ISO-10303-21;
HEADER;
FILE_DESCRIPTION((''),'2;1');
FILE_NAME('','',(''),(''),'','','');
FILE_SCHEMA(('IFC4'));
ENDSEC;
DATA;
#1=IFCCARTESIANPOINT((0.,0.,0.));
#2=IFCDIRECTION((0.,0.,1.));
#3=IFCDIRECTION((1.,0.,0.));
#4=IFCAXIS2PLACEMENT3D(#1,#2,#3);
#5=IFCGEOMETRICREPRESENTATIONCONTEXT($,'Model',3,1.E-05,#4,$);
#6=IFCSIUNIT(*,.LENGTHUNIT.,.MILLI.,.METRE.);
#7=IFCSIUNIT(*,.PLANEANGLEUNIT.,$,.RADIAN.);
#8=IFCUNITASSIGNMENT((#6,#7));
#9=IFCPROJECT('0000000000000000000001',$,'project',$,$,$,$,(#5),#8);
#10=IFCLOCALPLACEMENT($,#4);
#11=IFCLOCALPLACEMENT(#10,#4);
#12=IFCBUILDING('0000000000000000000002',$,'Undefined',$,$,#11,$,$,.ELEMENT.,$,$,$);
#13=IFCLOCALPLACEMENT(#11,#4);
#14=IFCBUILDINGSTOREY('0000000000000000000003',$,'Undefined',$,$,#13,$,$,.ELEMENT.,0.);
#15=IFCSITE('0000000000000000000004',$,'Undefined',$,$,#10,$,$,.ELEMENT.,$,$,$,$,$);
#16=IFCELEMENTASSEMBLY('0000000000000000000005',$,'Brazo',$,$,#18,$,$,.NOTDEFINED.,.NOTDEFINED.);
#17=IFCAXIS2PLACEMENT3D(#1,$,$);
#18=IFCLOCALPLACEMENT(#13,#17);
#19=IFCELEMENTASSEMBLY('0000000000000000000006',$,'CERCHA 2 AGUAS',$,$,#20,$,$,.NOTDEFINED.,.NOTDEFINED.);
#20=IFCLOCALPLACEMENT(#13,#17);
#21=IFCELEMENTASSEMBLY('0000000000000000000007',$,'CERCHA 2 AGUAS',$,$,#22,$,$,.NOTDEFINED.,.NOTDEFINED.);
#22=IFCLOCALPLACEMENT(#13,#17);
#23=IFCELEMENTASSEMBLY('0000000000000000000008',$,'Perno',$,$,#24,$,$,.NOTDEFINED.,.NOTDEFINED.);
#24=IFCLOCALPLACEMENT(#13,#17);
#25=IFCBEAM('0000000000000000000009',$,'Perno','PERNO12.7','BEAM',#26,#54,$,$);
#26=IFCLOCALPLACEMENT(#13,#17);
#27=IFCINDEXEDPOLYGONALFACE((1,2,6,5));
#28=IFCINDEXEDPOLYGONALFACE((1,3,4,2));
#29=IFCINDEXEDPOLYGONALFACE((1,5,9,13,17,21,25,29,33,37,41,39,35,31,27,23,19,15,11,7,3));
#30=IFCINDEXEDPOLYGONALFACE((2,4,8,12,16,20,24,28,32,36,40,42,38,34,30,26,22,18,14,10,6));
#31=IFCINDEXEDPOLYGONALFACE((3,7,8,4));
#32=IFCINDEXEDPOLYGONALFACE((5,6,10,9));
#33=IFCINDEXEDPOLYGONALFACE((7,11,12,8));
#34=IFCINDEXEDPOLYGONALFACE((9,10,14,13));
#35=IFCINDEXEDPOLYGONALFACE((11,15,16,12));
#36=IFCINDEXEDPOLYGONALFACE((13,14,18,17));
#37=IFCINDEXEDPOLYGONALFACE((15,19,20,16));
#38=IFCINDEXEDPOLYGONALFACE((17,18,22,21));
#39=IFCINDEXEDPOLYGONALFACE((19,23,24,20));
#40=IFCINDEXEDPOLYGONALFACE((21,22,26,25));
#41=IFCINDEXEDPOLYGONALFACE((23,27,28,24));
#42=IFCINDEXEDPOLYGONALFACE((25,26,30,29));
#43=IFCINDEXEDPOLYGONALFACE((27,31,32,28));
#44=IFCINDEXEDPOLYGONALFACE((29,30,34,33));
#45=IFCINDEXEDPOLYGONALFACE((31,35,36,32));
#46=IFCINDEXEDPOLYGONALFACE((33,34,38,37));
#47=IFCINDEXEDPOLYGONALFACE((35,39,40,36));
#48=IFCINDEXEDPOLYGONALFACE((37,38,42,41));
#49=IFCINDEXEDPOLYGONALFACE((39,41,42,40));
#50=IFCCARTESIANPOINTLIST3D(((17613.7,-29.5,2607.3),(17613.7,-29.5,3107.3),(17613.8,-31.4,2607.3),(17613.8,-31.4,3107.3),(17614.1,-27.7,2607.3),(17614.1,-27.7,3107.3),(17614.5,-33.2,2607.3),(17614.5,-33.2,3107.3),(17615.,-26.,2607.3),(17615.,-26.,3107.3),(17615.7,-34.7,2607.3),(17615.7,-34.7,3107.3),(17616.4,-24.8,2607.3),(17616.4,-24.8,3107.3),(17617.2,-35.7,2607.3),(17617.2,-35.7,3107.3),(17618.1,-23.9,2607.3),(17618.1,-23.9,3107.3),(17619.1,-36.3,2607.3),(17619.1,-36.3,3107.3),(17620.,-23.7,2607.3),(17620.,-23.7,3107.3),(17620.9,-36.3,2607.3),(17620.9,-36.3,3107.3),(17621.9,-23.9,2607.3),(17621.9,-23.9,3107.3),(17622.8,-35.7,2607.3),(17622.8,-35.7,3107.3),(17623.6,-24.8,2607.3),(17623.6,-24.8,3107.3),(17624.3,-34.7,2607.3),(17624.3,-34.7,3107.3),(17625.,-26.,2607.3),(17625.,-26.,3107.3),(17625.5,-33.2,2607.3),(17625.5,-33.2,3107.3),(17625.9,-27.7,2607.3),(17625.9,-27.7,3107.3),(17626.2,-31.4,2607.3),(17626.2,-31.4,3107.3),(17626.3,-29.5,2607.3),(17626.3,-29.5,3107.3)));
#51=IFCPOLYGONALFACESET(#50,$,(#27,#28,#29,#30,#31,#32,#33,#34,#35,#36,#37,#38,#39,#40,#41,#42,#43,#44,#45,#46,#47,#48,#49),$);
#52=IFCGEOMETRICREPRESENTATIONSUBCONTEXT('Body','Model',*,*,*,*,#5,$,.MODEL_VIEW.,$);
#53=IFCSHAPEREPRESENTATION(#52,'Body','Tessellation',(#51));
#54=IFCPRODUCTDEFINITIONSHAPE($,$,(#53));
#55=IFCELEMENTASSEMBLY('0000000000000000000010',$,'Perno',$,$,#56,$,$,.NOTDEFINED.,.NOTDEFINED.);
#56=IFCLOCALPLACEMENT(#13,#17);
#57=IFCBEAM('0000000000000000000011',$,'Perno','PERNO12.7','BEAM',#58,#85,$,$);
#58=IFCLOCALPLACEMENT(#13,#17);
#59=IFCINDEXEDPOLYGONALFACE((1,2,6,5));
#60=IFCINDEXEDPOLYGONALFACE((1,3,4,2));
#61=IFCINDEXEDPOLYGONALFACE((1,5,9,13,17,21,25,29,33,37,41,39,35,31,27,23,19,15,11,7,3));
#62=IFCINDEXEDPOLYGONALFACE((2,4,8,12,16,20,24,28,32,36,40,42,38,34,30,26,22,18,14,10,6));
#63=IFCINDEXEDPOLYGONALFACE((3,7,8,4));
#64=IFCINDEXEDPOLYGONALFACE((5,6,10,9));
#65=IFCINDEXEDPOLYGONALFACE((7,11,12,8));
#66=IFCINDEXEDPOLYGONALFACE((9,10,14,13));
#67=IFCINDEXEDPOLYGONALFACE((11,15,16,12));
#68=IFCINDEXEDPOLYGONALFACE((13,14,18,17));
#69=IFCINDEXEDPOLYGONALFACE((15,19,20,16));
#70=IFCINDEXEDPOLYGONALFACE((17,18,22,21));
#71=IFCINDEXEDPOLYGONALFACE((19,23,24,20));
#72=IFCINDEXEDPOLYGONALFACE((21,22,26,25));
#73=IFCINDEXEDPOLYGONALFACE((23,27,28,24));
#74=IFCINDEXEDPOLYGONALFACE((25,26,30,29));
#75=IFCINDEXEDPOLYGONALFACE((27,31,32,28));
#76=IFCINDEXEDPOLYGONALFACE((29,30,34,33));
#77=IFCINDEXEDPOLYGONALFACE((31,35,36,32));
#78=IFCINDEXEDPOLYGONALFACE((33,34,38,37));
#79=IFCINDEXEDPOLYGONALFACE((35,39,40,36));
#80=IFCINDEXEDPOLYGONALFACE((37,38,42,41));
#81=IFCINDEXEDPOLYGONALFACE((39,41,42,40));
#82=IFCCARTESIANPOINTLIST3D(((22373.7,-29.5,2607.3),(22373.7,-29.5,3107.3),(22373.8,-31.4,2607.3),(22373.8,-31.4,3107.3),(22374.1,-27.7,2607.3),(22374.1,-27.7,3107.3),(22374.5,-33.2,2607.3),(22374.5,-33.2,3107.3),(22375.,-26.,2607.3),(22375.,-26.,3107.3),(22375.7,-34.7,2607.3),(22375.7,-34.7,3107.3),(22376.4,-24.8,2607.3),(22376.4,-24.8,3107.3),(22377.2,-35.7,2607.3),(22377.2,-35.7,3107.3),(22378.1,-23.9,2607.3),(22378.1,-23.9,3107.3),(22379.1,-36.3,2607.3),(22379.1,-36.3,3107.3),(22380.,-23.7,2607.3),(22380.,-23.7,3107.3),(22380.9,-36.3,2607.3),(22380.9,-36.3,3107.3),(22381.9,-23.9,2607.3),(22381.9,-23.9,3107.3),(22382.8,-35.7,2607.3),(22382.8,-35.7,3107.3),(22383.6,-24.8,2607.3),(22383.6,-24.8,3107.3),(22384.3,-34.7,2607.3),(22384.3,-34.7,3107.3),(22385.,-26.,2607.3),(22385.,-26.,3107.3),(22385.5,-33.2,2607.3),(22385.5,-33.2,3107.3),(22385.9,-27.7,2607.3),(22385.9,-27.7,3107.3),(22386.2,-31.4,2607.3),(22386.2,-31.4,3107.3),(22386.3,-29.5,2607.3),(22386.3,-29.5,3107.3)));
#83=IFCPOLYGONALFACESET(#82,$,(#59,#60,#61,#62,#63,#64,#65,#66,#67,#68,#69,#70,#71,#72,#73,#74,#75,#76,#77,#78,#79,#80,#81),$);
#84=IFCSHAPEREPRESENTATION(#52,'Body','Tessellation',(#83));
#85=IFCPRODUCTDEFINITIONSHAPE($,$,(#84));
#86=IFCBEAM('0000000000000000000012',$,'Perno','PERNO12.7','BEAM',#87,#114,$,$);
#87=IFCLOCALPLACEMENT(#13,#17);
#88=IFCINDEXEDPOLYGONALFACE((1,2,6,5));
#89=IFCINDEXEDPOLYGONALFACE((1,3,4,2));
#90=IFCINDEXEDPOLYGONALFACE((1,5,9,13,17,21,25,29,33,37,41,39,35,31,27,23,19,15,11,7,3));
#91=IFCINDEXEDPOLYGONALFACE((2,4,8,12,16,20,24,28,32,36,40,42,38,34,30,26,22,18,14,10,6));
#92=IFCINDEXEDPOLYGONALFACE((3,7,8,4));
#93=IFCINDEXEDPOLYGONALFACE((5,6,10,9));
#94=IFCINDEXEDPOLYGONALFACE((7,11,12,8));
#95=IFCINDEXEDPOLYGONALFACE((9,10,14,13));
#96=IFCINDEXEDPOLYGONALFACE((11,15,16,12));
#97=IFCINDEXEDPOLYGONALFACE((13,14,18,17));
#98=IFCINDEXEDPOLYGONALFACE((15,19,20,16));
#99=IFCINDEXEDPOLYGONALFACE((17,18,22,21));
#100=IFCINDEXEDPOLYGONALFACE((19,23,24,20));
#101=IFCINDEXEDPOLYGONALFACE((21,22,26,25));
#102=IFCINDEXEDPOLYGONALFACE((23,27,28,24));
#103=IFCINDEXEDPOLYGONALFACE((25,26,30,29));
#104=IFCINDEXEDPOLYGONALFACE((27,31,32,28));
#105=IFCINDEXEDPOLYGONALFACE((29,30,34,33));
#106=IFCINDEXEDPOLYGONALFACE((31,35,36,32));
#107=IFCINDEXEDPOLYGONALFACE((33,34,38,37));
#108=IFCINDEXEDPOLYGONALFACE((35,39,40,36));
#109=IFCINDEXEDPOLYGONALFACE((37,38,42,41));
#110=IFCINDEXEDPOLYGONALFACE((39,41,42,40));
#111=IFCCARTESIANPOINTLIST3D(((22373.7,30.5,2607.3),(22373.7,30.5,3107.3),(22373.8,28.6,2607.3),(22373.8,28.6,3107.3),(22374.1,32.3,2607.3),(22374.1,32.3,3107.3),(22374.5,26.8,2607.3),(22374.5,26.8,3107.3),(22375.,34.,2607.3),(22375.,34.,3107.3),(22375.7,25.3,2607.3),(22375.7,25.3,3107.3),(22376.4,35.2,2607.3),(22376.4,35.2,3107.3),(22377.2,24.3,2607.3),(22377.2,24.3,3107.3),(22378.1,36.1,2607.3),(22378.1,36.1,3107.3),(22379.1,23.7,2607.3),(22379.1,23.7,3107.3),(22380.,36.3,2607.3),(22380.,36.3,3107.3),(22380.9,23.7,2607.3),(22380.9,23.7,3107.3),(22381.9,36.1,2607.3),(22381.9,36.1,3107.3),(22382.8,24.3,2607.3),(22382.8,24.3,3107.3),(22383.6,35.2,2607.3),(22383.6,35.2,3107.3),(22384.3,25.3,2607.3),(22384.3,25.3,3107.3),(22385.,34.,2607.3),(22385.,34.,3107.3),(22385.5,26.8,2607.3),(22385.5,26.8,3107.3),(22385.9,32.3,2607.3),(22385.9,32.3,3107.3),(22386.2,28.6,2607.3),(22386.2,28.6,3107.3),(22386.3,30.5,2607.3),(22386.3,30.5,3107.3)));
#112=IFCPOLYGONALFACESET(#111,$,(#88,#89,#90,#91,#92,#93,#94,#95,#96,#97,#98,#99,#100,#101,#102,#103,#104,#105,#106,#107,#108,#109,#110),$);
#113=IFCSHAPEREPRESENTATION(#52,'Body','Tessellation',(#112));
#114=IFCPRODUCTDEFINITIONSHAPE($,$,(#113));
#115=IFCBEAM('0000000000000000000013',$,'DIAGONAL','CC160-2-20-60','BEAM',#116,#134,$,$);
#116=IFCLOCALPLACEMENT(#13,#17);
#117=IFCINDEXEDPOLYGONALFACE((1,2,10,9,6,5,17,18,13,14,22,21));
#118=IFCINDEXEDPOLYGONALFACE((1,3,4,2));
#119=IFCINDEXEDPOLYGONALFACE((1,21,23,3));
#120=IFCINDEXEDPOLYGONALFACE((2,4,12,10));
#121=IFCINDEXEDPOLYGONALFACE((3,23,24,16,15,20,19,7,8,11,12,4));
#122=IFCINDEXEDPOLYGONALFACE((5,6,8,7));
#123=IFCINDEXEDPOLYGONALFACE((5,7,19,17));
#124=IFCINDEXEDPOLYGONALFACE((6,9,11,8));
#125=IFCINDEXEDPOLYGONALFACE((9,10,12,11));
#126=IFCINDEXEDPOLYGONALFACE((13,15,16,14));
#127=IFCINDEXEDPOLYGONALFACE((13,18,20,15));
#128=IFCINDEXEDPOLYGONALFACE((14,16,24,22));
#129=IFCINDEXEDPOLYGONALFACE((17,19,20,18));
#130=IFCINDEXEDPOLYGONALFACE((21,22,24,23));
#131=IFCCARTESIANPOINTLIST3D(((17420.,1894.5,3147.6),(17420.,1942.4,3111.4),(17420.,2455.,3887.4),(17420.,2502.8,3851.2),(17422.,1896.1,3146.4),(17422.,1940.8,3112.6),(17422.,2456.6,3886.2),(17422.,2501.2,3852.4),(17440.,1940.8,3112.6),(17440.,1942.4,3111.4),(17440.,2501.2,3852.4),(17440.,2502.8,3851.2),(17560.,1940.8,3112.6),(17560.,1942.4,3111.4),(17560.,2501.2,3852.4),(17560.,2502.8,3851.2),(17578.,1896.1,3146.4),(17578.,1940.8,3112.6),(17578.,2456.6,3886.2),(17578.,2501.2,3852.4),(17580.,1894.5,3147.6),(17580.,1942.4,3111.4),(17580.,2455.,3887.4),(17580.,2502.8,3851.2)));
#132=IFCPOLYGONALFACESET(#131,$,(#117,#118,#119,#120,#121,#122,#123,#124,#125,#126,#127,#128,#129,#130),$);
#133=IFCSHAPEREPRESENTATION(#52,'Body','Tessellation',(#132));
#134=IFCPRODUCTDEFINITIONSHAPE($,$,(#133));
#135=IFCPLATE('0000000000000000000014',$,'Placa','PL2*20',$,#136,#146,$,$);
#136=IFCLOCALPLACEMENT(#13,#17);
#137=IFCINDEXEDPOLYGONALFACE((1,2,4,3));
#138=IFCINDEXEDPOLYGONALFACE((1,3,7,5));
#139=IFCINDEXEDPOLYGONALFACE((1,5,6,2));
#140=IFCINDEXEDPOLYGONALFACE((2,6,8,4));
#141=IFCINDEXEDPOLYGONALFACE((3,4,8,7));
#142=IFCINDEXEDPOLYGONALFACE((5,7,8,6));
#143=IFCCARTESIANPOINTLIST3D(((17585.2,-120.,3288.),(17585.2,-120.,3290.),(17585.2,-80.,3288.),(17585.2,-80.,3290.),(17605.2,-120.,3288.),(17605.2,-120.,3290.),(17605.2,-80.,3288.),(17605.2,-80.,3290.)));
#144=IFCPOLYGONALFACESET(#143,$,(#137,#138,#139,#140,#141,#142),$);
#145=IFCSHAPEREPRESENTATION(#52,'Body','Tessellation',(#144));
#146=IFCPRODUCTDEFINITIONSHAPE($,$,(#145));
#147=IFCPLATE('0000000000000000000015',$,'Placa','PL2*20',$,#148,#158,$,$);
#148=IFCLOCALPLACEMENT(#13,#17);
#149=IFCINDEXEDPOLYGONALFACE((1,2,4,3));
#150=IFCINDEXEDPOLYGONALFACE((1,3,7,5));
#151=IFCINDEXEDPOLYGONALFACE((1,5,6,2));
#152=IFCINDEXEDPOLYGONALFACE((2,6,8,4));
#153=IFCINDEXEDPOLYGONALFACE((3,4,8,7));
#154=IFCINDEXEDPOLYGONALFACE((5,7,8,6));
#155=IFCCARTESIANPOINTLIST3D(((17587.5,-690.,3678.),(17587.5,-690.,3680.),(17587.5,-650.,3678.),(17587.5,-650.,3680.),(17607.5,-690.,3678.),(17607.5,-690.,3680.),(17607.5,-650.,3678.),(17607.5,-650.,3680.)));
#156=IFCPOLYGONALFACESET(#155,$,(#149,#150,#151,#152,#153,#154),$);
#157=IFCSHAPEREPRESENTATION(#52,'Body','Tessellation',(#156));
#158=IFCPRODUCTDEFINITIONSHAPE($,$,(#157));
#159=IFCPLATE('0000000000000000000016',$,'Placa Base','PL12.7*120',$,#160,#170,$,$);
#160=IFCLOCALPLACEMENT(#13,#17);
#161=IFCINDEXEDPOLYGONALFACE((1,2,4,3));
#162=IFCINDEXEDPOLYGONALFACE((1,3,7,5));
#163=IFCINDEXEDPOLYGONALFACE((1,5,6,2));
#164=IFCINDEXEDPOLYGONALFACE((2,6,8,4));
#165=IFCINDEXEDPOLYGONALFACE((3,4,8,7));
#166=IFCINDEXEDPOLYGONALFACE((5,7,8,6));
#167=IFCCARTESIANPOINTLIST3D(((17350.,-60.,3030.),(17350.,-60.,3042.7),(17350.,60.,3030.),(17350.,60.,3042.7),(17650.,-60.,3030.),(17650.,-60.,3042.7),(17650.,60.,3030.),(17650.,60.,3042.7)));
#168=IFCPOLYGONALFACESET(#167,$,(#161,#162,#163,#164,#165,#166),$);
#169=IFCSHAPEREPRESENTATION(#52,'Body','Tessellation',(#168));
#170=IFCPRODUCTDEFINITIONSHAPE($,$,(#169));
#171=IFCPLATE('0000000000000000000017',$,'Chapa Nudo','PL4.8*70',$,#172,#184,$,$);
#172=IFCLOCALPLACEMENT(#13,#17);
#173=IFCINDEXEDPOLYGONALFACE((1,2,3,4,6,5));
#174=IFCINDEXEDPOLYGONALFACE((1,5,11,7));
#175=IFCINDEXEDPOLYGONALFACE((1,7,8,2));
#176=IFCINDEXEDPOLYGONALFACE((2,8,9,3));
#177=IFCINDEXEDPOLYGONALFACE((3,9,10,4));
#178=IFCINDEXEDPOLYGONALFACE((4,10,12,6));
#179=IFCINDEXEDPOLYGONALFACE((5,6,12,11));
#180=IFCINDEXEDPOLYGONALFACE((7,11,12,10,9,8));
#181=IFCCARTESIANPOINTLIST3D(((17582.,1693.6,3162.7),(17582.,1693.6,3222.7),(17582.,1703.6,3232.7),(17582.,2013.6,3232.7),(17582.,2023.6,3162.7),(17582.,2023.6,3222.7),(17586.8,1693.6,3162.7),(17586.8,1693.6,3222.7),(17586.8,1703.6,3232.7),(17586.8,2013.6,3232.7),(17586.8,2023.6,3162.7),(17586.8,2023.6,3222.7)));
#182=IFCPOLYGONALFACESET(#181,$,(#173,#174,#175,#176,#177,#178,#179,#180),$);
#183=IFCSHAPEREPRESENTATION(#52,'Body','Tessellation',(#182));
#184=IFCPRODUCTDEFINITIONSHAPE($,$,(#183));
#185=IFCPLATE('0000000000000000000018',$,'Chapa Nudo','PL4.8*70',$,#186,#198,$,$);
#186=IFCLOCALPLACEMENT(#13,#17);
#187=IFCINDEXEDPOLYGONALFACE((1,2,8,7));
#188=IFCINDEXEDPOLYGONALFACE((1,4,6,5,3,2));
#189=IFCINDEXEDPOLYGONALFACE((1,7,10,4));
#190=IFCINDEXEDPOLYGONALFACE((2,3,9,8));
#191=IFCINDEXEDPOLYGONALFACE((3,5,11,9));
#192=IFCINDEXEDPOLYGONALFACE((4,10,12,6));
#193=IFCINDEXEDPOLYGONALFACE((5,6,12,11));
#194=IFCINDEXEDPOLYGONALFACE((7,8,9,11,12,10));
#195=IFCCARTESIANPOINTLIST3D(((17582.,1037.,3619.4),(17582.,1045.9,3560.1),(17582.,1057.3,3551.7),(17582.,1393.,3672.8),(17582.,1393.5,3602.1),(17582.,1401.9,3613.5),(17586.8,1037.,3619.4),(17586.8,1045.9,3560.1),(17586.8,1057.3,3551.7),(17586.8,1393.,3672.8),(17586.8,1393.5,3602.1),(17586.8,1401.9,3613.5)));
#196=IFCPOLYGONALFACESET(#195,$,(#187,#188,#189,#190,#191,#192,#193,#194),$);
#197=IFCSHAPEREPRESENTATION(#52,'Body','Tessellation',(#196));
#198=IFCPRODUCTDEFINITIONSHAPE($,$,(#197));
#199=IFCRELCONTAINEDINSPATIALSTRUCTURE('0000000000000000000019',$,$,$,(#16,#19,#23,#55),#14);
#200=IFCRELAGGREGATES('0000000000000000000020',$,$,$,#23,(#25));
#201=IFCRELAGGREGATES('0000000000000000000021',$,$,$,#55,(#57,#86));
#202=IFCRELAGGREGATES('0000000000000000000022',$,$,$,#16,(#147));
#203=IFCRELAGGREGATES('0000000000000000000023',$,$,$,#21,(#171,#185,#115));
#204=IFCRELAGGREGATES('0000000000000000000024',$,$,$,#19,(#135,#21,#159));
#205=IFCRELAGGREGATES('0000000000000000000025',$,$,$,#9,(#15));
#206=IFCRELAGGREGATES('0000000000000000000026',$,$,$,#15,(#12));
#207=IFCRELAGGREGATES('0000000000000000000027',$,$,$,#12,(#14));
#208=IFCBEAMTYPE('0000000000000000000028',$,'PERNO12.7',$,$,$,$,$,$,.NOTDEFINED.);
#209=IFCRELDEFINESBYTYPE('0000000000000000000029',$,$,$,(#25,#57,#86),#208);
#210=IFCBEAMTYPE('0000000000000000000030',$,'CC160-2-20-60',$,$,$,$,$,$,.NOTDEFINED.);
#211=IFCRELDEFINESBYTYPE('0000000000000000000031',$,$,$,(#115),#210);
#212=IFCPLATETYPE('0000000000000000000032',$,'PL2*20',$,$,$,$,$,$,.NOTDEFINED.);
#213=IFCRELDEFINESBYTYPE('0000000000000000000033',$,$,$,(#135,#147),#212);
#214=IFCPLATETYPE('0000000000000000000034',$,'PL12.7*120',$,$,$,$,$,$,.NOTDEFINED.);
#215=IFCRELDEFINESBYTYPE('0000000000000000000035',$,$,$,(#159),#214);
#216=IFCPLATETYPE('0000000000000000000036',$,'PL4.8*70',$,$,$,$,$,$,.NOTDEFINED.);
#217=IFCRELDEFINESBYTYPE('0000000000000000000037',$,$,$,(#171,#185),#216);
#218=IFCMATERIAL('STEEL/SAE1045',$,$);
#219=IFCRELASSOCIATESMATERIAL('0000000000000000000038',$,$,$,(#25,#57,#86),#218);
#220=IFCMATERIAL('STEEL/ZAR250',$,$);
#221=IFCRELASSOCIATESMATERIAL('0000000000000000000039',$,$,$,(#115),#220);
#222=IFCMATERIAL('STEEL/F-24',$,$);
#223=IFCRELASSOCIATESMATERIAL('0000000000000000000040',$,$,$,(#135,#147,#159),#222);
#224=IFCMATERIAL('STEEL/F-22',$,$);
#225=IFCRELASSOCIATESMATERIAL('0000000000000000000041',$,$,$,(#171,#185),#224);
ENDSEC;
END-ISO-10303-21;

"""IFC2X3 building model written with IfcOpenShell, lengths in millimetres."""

from ifc_helpers import new_model, si_unit, frame, origin_with_axes, origin_2d_with_axis, place, context, subcontext, project, spatial, polyline, circle, c_section, outline, extrude, material, type_object, element, aggregate, save


model = new_model("IFC2X3")

# Units and contexts
model_context = context("Model", 3, precision=1e-05, world=origin_with_axes())
body_context = subcontext(model_context, "Body", "Model", "MODEL_VIEW")
ifc_project = project(units=[si_unit("LENGTHUNIT", "METRE", prefix="MILLI"), si_unit("PLANEANGLEUNIT", "RADIAN")], contexts=[model_context])

# Site, building, storey
site_placement = place(None, origin_with_axes())
site = spatial("IfcSite", under=ifc_project, at=site_placement, Name="Undefined", CompositionType="ELEMENT")
building_placement = place(site_placement, origin_with_axes())
building = spatial("IfcBuilding", under=site, at=building_placement, Name="Undefined", CompositionType="ELEMENT")
storey_placement = place(building_placement, origin_with_axes())
storey = spatial("IfcBuildingStorey", under=building, at=storey_placement, Name="Undefined", CompositionType="ELEMENT", Elevation=0.0)

# Element assembly
ifc_material_1 = material(Name="STEEL/ZAR250")
assembly_1_placement = place(storey_placement, origin_with_axes())
assembly_1 = element("IfcElementAssembly", 1, at=assembly_1_placement, inside=storey, Name="Brazo", AssemblyPlace="NOTDEFINED", PredefinedType="NOTDEFINED")

# Element assemblies
assembly_2_placement = place(storey_placement, origin_with_axes())
assembly_2 = element("IfcElementAssembly", 2, at=assembly_2_placement, inside=storey, Name="CERCHA 2 AGUAS", AssemblyPlace="NOTDEFINED", PredefinedType="NOTDEFINED")
assembly_3_placement = place(assembly_2_placement, origin_with_axes())
assembly_3 = element("IfcElementAssembly", 3, at=assembly_3_placement, Name="CERCHA 2 AGUAS", AssemblyPlace="NOTDEFINED", PredefinedType="NOTDEFINED")
ifc_material_2 = material(Name="STEEL/F-22")

# Element assemblies, beams
assembly_4_placement = place(storey_placement, origin_with_axes())
assembly_4 = element("IfcElementAssembly", 4, at=assembly_4_placement, inside=storey, Name="Perno", AssemblyPlace="NOTDEFINED", PredefinedType="NOTDEFINED")
ifc_material_3 = material(Name="STEEL/SAE1045")
beam_type_1 = type_object("IfcBeamType", Name="PERNO12.7", PredefinedType="NOTDEFINED")
beam_1_placement = place(assembly_4_placement, frame((17620.0, -30.0, 3107.3), z_axis=(-1.0, 0.0, 0.0), x_axis=(0.0, 0.0, -1.0)))
beam_1 = element("IfcBeam", 5, at=beam_1_placement, type_object=beam_type_1, material=ifc_material_3, Name="Perno", Description="PERNO12.7", ObjectType="BEAM", context=body_context, shape_type="SweptSolid", body=[
    extrude(circle(Radius=6.3, at=origin_2d_with_axis()), frame((500.0, 0.0, 0.0), z_axis=(-1.0, 0.0, 0.0), x_axis=(0.0, -1.0, 0.0)), (0.0, 0.0, 1.0), 500.0),
])
aggregate(assembly_4, [beam_1])
assembly_5_placement = place(storey_placement, origin_with_axes())
assembly_5 = element("IfcElementAssembly", 6, at=assembly_5_placement, inside=storey, Name="Perno", AssemblyPlace="NOTDEFINED", PredefinedType="NOTDEFINED")
beam_2_placement = place(assembly_5_placement, frame((22380.0, -30.0, 3107.3), z_axis=(-1.0, 0.0, 0.0), x_axis=(0.0, 0.0, -1.0)))
beam_2 = element("IfcBeam", 7, at=beam_2_placement, type_object=beam_type_1, material=ifc_material_3, Name="Perno", Description="PERNO12.7", ObjectType="BEAM", context=body_context, shape_type="SweptSolid", body=[
    extrude(circle(Radius=6.3, at=origin_2d_with_axis()), frame((500.0, 0.0, 0.0), z_axis=(-1.0, 0.0, 0.0), x_axis=(0.0, -1.0, 0.0)), (0.0, 0.0, 1.0), 500.0),
])
beam_3_placement = place(assembly_5_placement, frame((22380.0, 30.0, 3107.3), z_axis=(-1.0, 0.0, 0.0), x_axis=(0.0, 0.0, -1.0)))
beam_3 = element("IfcBeam", 8, at=beam_3_placement, type_object=beam_type_1, material=ifc_material_3, Name="Perno", Description="PERNO12.7", ObjectType="BEAM", context=body_context, shape_type="SweptSolid", body=[
    extrude(circle(Radius=6.3, at=origin_2d_with_axis()), frame((500.0, 0.0, 0.0), z_axis=(-1.0, 0.0, 0.0), x_axis=(0.0, -1.0, 0.0)), (0.0, 0.0, 1.0), 500.0),
])
aggregate(assembly_5, [beam_2, beam_3])

# Beam
beam_type_2 = type_object("IfcBeamType", Name="CC160-2-20-60", PredefinedType="NOTDEFINED")
beam_4_placement = place(assembly_3_placement, frame((17500.0, 1918.5, 3129.5), z_axis=(1.0, 0.0, 0.0), x_axis=(0.0, 0.603858, 0.797092)))
beam_4 = element("IfcBeam", 9, at=beam_4_placement, type_object=beam_type_2, material=ifc_material_1, Name="DIAGONAL", Description="CC160-2-20-60", ObjectType="BEAM", context=body_context, shape_type="SweptSolid", body=[
    extrude(c_section(Depth=160.0, Width=60.0, WallThickness=2.0, Girth=20.0, at=origin_2d_with_axis()), frame((928.1, 0.0, 0.0), z_axis=(-1.0, 0.0, 0.0), x_axis=(0.0, -1.0, 0.0)), (0.0, 0.0, 1.0), 928.1),
])

# Plates
ifc_material_4 = material(Name="STEEL/F-24")
plate_type_1 = type_object("IfcPlateType", Name="PL2*20", PredefinedType="NOTDEFINED")
plate_1_placement = place(assembly_2_placement, frame((17605.2, -120.0, 3289.0), z_axis=(0.0, -0.000121, 1.0), x_axis=(0.000085, 1.0, 0.000121)))
plate_1 = element("IfcPlate", 10, at=plate_1_placement, type_object=plate_type_1, material=ifc_material_4, Name="Placa", Description="PL2*20", context=body_context, shape_type="SweptSolid", body=[
    extrude(outline(polyline([(0.0, 0.0), (40.0, 0.0), (40.0, 20.0), (0.0, 20.0), (0.0, 0.0)])), frame((0.0, 0.0, -1.0), z_axis=(0.0, 0.0, 1.0), x_axis=(1.0, 0.0, 0.0)), (0.0, 0.0, 1.0), 2.0),
])
plate_2_placement = place(assembly_1_placement, frame((17587.5, -690.0, 3679.0), z_axis=(0.0, 0.000121, -1.0), x_axis=(-0.000071, 1.0, 0.000121)))
plate_2 = element("IfcPlate", 11, at=plate_2_placement, type_object=plate_type_1, material=ifc_material_4, Name="Placa", Description="PL2*20", context=body_context, shape_type="SweptSolid", body=[
    extrude(outline(polyline([(0.0, 0.0), (40.0, 0.0), (40.0, 20.0), (0.0, 20.0), (0.0, 0.0)])), frame((0.0, 0.0, -1.0), z_axis=(0.0, 0.0, 1.0), x_axis=(1.0, 0.0, 0.0)), (0.0, 0.0, 1.0), 2.0),
])
aggregate(assembly_1, [plate_2])
plate_type_2 = type_object("IfcPlateType", Name="PL12.7*120", PredefinedType="NOTDEFINED")
plate_3_placement = place(assembly_2_placement, frame((17650.0, 60.0, 3036.3), z_axis=(0.0, 0.0, 1.0), x_axis=(-1.0, 0.0, 0.0)))
plate_3 = element("IfcPlate", 12, at=plate_3_placement, type_object=plate_type_2, material=ifc_material_4, Name="Placa Base", Description="PL12.7*120", context=body_context, shape_type="SweptSolid", body=[
    extrude(outline(polyline([(0.0, 0.0), (300.0, 0.0), (300.0, 120.0), (0.0, 120.0), (0.0, 0.0)])), frame((0.0, 0.0, -6.3), z_axis=(0.0, 0.0, 1.0), x_axis=(1.0, 0.0, 0.0)), (0.0, 0.0, 1.0), 12.7),
])
plate_type_3 = type_object("IfcPlateType", Name="PL4.8*70", PredefinedType="NOTDEFINED")
plate_4_placement = place(assembly_3_placement, frame((17584.4, 1693.6, 3232.7), z_axis=(1.0, 0.0, 0.0), x_axis=(0.0, 0.0, -1.0)))
plate_4 = element("IfcPlate", 13, at=plate_4_placement, type_object=plate_type_3, material=ifc_material_2, Name="Chapa Nudo", Description="PL4.8*70", context=body_context, shape_type="SweptSolid", body=[
    extrude(outline(polyline([(0.0, 10.0), (10.0, 0.0), (70.0, 0.0), (70.0, 330.0), (10.0, 330.0), (0.0, 320.0), (0.0, 10.0)])), frame((0.0, 0.0, -2.4), z_axis=(0.0, 0.0, 1.0), x_axis=(1.0, 0.0, 0.0)), (0.0, 0.0, 1.0), 4.8),
])
plate_5_placement = place(assembly_3_placement, frame((17584.4, 1037.0, 3619.4), z_axis=(1.0, 0.0, 0.0), x_axis=(0.0, 0.148337, -0.988937)))
plate_5 = element("IfcPlate", 14, at=plate_5_placement, type_object=plate_type_3, material=ifc_material_2, Name="Chapa Nudo", Description="PL4.8*70", context=body_context, shape_type="SweptSolid", body=[
    extrude(outline(polyline([(0.0, 0.0), (60.0, 0.0), (70.0, 10.0), (70.0, 350.0), (60.0, 360.0), (0.0, 360.0), (0.0, 0.0)])), frame((0.0, 0.0, -2.4), z_axis=(0.0, 0.0, 1.0), x_axis=(1.0, 0.0, 0.0)), (0.0, 0.0, 1.0), 4.8),
])

aggregate(assembly_3, [plate_4, plate_5, beam_4])
aggregate(assembly_2, [plate_1, assembly_3, plate_3])

save(model, "model.ifc")
